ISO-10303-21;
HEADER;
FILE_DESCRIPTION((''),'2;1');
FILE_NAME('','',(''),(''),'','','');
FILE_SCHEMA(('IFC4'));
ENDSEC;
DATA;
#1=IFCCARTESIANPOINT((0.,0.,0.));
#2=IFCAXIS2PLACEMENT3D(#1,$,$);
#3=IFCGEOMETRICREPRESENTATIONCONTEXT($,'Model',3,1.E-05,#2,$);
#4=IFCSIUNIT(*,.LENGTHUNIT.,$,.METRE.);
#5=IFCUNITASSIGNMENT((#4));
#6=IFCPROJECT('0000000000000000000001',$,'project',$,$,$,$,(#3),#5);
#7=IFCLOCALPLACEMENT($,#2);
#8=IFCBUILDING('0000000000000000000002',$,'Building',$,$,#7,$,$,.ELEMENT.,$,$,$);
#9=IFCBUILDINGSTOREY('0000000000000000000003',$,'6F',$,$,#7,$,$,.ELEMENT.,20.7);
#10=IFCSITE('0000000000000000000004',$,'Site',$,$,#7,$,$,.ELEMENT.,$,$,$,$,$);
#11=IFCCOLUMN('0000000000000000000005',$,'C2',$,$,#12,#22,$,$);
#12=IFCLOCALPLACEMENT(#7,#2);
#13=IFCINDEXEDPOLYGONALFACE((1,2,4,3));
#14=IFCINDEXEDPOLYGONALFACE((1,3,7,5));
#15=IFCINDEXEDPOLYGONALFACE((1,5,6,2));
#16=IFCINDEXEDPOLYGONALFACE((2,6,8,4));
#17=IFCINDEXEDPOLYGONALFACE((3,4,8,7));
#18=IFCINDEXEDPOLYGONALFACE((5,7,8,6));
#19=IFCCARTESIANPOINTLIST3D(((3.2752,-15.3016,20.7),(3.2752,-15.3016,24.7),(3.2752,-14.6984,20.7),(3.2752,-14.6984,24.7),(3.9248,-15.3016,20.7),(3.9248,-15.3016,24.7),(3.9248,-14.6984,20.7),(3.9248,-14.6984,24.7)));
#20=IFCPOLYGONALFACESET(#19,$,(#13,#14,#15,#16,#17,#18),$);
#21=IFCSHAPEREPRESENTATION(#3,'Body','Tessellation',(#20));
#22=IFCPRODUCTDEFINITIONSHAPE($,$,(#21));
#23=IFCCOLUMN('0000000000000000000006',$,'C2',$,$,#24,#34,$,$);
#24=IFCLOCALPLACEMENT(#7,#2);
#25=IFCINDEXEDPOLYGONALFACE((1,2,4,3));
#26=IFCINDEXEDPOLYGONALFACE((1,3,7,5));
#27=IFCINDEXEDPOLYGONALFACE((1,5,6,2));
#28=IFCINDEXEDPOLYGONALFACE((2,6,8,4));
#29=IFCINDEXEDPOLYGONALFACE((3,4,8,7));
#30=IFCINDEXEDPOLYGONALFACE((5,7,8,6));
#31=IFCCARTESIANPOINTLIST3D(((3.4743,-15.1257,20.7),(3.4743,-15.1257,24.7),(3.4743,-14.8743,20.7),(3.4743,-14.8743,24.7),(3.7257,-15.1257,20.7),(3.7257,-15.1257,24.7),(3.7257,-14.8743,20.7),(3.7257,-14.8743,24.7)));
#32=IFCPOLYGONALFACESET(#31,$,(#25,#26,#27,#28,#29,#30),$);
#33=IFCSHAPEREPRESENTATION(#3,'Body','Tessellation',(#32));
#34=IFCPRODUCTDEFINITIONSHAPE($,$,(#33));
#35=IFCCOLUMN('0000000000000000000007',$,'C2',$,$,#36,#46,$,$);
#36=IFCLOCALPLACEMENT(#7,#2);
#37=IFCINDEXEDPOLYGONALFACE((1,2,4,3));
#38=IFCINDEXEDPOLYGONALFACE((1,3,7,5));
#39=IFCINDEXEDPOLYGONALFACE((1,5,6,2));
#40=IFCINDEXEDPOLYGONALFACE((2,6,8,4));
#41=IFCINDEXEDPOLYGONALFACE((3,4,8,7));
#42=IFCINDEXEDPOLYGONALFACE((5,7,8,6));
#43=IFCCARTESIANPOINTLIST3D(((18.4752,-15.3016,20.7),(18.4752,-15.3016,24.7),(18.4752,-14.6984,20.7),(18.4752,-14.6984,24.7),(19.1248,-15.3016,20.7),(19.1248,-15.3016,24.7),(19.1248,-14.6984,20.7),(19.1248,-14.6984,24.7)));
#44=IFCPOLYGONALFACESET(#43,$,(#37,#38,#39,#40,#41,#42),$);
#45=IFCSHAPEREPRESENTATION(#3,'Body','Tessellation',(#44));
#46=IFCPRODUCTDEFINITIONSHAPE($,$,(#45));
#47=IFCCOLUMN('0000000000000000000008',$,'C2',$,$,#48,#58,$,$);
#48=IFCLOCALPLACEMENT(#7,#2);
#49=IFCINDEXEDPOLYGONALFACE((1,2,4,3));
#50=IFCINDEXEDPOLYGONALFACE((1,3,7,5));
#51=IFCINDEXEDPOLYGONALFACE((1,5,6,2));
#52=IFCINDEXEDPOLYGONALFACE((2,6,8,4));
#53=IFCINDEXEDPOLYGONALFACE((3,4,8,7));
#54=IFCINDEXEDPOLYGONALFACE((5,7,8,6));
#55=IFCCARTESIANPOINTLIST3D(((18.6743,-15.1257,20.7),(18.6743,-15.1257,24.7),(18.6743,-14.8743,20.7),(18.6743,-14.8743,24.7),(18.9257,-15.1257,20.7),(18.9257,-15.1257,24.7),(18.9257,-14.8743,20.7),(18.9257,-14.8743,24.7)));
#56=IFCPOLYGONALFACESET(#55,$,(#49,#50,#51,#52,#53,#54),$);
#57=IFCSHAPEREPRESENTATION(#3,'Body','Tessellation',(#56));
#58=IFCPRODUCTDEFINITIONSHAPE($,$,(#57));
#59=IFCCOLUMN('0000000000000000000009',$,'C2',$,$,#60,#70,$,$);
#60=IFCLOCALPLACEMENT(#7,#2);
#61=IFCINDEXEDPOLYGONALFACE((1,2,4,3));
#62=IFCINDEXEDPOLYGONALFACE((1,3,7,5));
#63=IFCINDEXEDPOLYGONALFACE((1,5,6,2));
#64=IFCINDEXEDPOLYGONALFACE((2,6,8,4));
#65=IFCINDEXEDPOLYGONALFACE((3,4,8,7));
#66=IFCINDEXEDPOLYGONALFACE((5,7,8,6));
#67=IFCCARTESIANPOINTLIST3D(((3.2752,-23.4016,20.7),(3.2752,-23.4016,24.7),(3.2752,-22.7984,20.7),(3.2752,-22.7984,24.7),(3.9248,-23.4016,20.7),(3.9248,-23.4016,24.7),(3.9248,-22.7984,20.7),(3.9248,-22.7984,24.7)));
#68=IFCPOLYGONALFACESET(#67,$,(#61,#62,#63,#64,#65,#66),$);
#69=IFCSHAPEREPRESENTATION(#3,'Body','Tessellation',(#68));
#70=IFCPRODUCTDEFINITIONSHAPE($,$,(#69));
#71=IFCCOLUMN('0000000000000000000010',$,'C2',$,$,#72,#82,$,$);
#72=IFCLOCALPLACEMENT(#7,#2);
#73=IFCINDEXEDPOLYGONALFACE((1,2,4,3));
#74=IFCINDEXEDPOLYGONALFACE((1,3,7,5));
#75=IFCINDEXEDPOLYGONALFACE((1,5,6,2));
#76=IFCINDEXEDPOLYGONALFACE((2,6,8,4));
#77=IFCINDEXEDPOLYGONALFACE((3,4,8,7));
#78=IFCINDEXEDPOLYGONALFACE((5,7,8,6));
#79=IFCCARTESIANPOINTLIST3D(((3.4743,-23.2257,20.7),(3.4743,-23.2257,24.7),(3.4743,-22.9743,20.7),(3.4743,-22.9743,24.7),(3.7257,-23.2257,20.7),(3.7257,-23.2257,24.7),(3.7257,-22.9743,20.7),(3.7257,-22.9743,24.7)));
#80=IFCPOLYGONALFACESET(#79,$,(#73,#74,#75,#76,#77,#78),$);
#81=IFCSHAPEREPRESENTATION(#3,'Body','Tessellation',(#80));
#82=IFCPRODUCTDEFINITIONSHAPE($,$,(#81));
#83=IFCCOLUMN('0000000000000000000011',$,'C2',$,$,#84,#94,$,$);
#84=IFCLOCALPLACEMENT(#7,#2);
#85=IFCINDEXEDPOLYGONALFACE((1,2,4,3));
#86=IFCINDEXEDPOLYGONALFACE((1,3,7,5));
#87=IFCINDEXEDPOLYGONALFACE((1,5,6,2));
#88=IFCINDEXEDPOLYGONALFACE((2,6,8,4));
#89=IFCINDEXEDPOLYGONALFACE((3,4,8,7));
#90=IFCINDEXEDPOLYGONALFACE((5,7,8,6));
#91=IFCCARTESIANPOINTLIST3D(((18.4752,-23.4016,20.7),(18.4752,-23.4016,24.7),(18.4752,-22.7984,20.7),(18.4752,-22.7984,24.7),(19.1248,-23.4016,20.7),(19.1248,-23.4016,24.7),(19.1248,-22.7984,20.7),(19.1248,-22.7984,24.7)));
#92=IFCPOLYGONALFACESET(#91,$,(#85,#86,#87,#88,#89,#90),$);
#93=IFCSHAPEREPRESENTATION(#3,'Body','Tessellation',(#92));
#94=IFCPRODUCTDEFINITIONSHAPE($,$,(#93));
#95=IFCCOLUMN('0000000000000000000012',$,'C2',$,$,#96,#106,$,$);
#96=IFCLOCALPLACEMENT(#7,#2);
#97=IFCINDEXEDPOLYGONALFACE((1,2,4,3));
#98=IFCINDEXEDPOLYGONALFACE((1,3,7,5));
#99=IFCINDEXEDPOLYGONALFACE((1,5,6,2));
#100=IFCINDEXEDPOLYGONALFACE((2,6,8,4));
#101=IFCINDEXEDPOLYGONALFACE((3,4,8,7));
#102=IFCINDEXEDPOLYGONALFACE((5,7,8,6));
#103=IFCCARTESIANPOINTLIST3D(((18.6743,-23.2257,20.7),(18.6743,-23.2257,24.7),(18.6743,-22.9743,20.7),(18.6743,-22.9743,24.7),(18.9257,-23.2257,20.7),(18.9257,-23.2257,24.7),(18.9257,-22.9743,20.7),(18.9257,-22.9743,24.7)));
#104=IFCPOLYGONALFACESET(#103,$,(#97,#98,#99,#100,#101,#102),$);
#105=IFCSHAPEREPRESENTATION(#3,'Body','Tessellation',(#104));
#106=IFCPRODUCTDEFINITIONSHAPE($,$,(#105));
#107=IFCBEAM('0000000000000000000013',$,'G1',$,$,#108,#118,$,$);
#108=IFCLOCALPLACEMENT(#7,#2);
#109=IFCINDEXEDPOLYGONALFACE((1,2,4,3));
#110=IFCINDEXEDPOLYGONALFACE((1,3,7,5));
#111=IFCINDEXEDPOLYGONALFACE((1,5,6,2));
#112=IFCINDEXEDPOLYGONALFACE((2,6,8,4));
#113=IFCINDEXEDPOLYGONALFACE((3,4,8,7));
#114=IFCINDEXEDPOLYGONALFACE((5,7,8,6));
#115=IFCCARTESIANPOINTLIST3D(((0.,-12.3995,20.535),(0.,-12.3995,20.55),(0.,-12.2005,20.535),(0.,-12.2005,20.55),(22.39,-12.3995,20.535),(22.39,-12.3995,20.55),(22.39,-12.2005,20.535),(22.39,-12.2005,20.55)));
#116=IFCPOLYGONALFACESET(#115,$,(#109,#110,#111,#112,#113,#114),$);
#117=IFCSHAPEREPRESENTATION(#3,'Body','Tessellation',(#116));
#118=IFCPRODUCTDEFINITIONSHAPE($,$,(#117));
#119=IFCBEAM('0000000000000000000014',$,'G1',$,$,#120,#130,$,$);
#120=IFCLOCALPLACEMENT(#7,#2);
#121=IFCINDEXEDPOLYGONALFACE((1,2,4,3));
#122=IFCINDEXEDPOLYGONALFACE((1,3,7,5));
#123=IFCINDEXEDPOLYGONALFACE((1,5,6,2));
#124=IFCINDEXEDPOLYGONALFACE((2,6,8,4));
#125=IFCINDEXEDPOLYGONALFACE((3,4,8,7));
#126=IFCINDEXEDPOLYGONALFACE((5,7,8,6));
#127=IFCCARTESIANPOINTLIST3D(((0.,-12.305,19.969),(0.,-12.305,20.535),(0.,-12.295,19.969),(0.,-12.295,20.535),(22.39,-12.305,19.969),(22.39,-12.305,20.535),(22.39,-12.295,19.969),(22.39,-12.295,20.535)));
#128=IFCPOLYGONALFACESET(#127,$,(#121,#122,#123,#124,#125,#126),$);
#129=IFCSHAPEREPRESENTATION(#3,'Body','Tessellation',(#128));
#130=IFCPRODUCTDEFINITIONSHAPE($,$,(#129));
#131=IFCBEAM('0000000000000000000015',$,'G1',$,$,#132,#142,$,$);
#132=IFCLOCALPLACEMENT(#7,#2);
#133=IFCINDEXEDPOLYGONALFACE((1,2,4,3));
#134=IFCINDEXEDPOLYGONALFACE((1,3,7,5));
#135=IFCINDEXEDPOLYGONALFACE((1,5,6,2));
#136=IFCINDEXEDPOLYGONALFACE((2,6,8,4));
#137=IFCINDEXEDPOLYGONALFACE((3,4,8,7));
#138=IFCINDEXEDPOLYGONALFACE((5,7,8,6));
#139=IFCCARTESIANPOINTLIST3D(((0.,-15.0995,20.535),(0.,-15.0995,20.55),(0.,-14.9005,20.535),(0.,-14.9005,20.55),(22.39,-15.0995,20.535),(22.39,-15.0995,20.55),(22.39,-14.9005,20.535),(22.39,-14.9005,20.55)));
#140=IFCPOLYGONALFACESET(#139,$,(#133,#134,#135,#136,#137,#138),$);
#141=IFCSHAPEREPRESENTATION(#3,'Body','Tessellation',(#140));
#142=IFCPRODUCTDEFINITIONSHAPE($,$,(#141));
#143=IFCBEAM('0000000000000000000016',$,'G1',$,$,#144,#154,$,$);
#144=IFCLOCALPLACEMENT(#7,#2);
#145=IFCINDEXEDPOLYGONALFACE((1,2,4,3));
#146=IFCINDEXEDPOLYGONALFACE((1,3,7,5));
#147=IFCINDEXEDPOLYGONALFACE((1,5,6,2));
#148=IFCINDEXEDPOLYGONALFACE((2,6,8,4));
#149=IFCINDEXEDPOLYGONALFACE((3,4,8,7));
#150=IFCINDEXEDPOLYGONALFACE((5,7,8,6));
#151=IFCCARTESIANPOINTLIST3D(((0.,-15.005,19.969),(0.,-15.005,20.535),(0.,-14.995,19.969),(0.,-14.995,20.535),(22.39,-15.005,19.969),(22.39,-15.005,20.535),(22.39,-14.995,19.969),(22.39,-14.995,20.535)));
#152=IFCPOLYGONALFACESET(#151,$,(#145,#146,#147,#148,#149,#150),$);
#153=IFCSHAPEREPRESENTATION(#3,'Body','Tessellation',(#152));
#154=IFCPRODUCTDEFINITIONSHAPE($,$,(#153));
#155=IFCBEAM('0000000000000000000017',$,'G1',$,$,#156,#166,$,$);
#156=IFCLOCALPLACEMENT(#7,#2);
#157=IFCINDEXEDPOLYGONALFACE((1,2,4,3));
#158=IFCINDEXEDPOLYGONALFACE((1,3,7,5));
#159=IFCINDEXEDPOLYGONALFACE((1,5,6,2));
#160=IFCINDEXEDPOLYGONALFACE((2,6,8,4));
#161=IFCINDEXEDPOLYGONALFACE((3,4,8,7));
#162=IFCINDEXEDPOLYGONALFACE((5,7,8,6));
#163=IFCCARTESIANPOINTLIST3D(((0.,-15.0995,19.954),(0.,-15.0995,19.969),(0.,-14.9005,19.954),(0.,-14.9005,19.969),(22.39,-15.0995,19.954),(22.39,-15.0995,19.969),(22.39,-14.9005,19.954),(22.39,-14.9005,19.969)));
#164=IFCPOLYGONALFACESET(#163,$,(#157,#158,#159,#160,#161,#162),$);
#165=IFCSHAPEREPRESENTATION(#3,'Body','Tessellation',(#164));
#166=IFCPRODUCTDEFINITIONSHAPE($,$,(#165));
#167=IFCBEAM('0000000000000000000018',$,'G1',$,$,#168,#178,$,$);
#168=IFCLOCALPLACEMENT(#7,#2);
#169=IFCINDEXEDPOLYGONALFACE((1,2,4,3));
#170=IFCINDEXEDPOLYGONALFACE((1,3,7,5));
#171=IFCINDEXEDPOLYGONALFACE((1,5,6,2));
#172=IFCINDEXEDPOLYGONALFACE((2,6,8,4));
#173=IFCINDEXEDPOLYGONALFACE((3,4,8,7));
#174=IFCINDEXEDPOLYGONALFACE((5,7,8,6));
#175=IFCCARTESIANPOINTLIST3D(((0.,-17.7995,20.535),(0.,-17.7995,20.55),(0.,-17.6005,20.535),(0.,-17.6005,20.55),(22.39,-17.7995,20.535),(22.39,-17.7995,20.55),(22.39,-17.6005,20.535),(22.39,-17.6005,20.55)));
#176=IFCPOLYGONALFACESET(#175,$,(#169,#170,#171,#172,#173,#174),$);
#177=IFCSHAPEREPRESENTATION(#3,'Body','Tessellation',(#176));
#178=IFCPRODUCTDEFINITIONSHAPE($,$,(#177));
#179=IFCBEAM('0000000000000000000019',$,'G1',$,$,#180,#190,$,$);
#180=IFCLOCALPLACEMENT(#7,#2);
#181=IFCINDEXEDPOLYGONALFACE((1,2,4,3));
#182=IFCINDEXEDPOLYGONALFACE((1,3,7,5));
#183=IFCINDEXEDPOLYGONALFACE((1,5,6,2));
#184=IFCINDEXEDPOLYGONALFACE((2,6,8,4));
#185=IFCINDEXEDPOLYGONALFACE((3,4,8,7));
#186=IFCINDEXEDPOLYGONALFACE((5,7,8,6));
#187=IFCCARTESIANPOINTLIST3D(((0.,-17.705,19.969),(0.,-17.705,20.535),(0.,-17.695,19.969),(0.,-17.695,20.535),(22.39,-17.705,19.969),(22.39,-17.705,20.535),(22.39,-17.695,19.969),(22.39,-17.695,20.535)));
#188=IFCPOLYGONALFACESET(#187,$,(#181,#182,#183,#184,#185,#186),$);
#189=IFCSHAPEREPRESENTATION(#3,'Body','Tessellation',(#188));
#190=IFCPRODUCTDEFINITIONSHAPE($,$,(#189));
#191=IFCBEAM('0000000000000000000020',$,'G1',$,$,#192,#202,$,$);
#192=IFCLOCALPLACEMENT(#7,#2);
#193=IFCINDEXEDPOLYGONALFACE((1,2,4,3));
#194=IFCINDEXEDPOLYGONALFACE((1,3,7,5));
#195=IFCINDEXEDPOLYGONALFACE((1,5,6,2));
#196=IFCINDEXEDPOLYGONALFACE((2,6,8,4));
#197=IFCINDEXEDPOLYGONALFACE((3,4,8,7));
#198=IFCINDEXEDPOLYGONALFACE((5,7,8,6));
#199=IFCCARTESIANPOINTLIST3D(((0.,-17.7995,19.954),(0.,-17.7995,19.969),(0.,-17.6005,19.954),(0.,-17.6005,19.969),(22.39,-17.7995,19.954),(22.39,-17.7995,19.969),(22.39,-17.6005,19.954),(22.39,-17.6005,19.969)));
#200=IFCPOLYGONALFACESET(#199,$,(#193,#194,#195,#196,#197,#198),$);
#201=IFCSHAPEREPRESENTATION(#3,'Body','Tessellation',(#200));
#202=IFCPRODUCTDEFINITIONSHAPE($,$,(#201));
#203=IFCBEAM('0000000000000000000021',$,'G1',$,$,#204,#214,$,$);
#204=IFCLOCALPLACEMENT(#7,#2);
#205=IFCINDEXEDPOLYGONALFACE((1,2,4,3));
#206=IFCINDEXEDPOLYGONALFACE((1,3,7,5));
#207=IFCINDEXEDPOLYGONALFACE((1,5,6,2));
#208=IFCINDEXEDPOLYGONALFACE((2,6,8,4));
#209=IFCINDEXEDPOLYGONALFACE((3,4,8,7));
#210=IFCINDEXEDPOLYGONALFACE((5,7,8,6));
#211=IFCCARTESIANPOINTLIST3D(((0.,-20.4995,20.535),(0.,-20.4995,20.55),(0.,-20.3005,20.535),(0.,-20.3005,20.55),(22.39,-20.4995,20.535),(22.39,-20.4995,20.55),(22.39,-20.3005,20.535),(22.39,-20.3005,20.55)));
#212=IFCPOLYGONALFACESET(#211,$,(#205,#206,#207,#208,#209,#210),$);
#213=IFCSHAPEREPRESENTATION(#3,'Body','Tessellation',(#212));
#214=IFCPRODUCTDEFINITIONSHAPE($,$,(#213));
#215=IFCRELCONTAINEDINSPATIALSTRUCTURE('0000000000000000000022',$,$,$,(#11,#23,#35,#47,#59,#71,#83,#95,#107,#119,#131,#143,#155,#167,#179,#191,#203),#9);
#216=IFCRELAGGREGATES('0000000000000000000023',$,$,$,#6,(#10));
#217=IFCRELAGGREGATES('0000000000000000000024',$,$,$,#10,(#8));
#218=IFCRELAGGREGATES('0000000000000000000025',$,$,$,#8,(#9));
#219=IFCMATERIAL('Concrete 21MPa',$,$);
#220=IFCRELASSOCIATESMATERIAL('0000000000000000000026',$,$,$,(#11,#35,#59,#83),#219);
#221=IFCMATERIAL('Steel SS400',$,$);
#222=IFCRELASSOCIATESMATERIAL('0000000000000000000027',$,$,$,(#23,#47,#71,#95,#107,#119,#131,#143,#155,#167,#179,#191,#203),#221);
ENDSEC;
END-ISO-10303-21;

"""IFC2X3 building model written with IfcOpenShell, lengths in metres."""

from ifc_helpers import new_model, si_unit, frame, origin, origin_2d, place, context, project, spatial, rectangle, extrude, material, element, save


model = new_model("IFC2X3")

# Units and contexts
model_context = context("Model", 3, precision=1e-05, world=origin())
ifc_project = project(units=[si_unit("LENGTHUNIT", "METRE")], contexts=[model_context])

# Site, building, storey
placement = place(None, origin())
site = spatial("IfcSite", under=ifc_project, at=placement, Name="Site", CompositionType="ELEMENT")
building = spatial("IfcBuilding", under=site, at=placement, Name="Building", CompositionType="ELEMENT")
storey = spatial("IfcBuildingStorey", under=building, at=placement, Name="6F", CompositionType="ELEMENT", Elevation=20.7)

# Columns
ifc_material_1 = material(Name="Concrete 21MPa")
column_1_placement = place(None, frame((3.6, -15.0, 20.7)))
element("IfcColumn", 1, at=column_1_placement, inside=storey, material=ifc_material_1, Name="C2", context=model_context, shape_type="SweptSolid", body=[
    extrude(rectangle(XDim=0.6496, YDim=0.6032, at=origin_2d()), origin(), (0.0, 0.0, 1.0), 4.0),
])
ifc_material_2 = material(Name="Steel SS400")
column_2_placement = place(None, frame((3.6, -15.0, 20.7)))
element("IfcColumn", 2, at=column_2_placement, inside=storey, material=ifc_material_2, Name="C2", context=model_context, shape_type="SweptSolid", body=[
    extrude(rectangle(XDim=0.2513, YDim=0.2513, at=origin_2d()), origin(), (0.0, 0.0, 1.0), 4.0),
])
column_3_placement = place(None, frame((18.8, -15.0, 20.7)))
element("IfcColumn", 3, at=column_3_placement, inside=storey, material=ifc_material_1, Name="C2", context=model_context, shape_type="SweptSolid", body=[
    extrude(rectangle(XDim=0.6496, YDim=0.6032, at=origin_2d()), origin(), (0.0, 0.0, 1.0), 4.0),
])
column_4_placement = place(None, frame((18.8, -15.0, 20.7)))
element("IfcColumn", 4, at=column_4_placement, inside=storey, material=ifc_material_2, Name="C2", context=model_context, shape_type="SweptSolid", body=[
    extrude(rectangle(XDim=0.2513, YDim=0.2513, at=origin_2d()), origin(), (0.0, 0.0, 1.0), 4.0),
])
column_5_placement = place(None, frame((3.6, -23.1, 20.7)))
element("IfcColumn", 5, at=column_5_placement, inside=storey, material=ifc_material_1, Name="C2", context=model_context, shape_type="SweptSolid", body=[
    extrude(rectangle(XDim=0.6496, YDim=0.6032, at=origin_2d()), origin(), (0.0, 0.0, 1.0), 4.0),
])
column_6_placement = place(None, frame((3.6, -23.1, 20.7)))
element("IfcColumn", 6, at=column_6_placement, inside=storey, material=ifc_material_2, Name="C2", context=model_context, shape_type="SweptSolid", body=[
    extrude(rectangle(XDim=0.2513, YDim=0.2513, at=origin_2d()), origin(), (0.0, 0.0, 1.0), 4.0),
])
column_7_placement = place(None, frame((18.8, -23.1, 20.7)))
element("IfcColumn", 7, at=column_7_placement, inside=storey, material=ifc_material_1, Name="C2", context=model_context, shape_type="SweptSolid", body=[
    extrude(rectangle(XDim=0.6496, YDim=0.6032, at=origin_2d()), origin(), (0.0, 0.0, 1.0), 4.0),
])
column_8_placement = place(None, frame((18.8, -23.1, 20.7)))
element("IfcColumn", 8, at=column_8_placement, inside=storey, material=ifc_material_2, Name="C2", context=model_context, shape_type="SweptSolid", body=[
    extrude(rectangle(XDim=0.2513, YDim=0.2513, at=origin_2d()), origin(), (0.0, 0.0, 1.0), 4.0),
])

# Beams
beam_1_placement = place(None, frame((11.195, -12.3, 20.535)))
element("IfcBeam", 9, at=beam_1_placement, inside=storey, material=ifc_material_2, Name="G1", context=model_context, shape_type="SweptSolid", body=[
    extrude(rectangle(XDim=22.39, YDim=0.199, at=origin_2d()), origin(), (0.0, 0.0, 1.0), 0.015),
])
beam_2_placement = place(None, frame((11.195, -12.3, 19.969)))
element("IfcBeam", 10, at=beam_2_placement, inside=storey, material=ifc_material_2, Name="G1", context=model_context, shape_type="SweptSolid", body=[
    extrude(rectangle(XDim=22.39, YDim=0.01, at=origin_2d()), origin(), (0.0, 0.0, 1.0), 0.566),
])
beam_3_placement = place(None, frame((11.195, -15.0, 20.535)))
element("IfcBeam", 11, at=beam_3_placement, inside=storey, material=ifc_material_2, Name="G1", context=model_context, shape_type="SweptSolid", body=[
    extrude(rectangle(XDim=22.39, YDim=0.199, at=origin_2d()), origin(), (0.0, 0.0, 1.0), 0.015),
])
beam_4_placement = place(None, frame((11.195, -15.0, 19.969)))
element("IfcBeam", 12, at=beam_4_placement, inside=storey, material=ifc_material_2, Name="G1", context=model_context, shape_type="SweptSolid", body=[
    extrude(rectangle(XDim=22.39, YDim=0.01, at=origin_2d()), origin(), (0.0, 0.0, 1.0), 0.566),
])
for number, where, name in (
    (13, (11.195, -15.0, 19.954), "G1"),
    (14, (11.195, -17.7, 20.535), "G1"),
):
    element("IfcBeam", number, at=place(None, frame(where)), inside=storey, material=ifc_material_2, Name=name, context=model_context, shape_type="SweptSolid", body=[
        extrude(rectangle(XDim=22.39, YDim=0.199, at=origin_2d()), origin(), (0.0, 0.0, 1.0), 0.015),
    ])
beam_5_placement = place(None, frame((11.195, -17.7, 19.969)))
element("IfcBeam", 15, at=beam_5_placement, inside=storey, material=ifc_material_2, Name="G1", context=model_context, shape_type="SweptSolid", body=[
    extrude(rectangle(XDim=22.39, YDim=0.01, at=origin_2d()), origin(), (0.0, 0.0, 1.0), 0.566),
])
for number, where, name in (
    (16, (11.195, -17.7, 19.954), "G1"),
    (17, (11.195, -20.4, 20.535), "G1"),
):
    element("IfcBeam", number, at=place(None, frame(where)), inside=storey, material=ifc_material_2, Name=name, context=model_context, shape_type="SweptSolid", body=[
        extrude(rectangle(XDim=22.39, YDim=0.199, at=origin_2d()), origin(), (0.0, 0.0, 1.0), 0.015),
    ])

save(model, "model.ifc")
